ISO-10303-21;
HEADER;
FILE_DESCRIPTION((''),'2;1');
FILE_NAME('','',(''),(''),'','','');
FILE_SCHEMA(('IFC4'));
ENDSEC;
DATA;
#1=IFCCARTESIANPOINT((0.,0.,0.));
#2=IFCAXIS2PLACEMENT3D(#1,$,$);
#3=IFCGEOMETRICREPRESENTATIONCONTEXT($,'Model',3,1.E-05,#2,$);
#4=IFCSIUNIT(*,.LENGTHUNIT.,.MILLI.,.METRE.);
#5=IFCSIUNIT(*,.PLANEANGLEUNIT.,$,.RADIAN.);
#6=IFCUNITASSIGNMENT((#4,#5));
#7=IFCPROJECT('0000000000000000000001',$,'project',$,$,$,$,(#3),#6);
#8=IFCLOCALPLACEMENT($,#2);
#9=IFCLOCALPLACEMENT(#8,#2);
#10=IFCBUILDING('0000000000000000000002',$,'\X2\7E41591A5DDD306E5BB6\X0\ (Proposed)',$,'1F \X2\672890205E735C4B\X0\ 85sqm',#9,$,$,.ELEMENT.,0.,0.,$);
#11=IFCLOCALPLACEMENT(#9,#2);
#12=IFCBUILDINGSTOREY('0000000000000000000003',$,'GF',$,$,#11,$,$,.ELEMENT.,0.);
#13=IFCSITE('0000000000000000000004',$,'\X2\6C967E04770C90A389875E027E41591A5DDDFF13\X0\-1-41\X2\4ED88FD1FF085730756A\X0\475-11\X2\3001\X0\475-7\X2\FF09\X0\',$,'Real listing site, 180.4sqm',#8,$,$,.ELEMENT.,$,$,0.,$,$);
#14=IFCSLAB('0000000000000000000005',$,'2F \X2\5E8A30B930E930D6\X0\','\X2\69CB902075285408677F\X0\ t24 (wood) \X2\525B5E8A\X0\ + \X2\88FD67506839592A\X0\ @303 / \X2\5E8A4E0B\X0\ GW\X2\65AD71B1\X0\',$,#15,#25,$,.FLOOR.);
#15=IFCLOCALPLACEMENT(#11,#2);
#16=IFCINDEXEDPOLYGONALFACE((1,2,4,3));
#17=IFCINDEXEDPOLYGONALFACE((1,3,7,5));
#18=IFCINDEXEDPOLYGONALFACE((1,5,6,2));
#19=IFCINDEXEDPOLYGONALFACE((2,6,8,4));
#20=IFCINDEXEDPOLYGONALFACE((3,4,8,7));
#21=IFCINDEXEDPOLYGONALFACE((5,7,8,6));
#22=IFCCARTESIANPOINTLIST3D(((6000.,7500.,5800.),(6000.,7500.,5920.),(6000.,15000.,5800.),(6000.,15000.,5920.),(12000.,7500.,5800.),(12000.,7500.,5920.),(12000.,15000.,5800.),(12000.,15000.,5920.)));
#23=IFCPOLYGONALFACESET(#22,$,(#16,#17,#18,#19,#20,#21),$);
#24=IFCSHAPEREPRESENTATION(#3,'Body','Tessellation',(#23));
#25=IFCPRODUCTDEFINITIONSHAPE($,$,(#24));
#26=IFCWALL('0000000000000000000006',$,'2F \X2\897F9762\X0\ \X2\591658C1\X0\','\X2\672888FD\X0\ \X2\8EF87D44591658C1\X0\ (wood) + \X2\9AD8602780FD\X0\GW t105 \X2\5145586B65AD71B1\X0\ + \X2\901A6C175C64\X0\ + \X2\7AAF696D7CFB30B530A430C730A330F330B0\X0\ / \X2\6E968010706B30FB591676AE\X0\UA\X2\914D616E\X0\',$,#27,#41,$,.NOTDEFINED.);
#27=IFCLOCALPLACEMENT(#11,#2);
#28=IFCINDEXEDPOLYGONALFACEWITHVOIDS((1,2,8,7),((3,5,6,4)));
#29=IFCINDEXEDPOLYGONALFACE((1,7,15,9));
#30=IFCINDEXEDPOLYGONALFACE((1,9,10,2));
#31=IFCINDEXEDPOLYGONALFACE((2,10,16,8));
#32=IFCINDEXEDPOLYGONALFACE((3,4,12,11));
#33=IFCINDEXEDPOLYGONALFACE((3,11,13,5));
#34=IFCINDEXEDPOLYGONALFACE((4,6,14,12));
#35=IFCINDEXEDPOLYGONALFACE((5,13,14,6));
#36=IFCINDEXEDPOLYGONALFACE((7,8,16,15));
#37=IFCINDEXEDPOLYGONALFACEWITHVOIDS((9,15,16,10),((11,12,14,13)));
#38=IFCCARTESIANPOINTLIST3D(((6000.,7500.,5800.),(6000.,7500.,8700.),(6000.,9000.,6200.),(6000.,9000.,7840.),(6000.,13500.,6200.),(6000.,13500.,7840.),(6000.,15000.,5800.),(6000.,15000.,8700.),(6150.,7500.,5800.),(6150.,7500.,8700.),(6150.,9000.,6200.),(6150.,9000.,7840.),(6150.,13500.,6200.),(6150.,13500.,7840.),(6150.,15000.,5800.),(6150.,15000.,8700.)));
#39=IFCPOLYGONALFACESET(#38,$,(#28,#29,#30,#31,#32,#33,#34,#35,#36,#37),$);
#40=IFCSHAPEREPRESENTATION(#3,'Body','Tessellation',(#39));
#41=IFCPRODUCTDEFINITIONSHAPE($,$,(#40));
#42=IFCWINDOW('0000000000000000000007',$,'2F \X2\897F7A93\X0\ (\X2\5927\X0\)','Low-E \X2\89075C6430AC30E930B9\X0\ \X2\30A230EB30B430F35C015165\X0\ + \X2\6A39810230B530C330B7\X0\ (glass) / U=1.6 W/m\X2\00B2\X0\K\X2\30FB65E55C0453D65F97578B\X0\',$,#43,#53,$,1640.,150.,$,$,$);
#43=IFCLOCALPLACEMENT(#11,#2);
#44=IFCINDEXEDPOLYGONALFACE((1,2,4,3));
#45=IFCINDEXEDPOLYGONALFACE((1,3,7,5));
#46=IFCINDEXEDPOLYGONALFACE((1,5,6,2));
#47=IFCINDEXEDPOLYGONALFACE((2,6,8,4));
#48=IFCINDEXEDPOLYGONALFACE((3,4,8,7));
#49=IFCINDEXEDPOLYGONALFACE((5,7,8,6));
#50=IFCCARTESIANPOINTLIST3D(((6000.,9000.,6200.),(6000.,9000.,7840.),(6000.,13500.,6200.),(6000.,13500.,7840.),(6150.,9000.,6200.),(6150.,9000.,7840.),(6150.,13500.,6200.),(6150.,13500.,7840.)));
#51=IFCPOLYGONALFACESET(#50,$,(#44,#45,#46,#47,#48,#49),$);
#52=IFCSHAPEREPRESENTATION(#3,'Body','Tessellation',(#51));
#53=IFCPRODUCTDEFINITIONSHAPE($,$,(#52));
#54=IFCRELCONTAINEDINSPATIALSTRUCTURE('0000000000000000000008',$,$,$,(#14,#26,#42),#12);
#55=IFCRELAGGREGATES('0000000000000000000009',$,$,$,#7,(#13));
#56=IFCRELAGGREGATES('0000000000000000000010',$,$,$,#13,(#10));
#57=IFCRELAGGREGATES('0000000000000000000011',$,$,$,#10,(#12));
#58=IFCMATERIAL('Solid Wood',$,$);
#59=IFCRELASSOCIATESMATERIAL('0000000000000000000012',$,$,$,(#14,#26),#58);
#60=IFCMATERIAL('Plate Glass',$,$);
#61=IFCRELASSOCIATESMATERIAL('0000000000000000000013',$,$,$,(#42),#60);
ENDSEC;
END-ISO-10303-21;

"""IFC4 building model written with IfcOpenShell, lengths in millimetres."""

from ifc_helpers import new_model, si_unit, frame, frame_2d, origin, place, context, project, spatial, rectangle, extrude, material, element, fill, save


model = new_model("IFC4")

# Units and contexts
model_context = context("Model", 3, precision=1e-05, world=origin())
ifc_project = project(units=[si_unit("LENGTHUNIT", "METRE", prefix="MILLI"), si_unit("PLANEANGLEUNIT", "RADIAN")], contexts=[model_context])

# Site, building, storey
site_placement = place(None, origin())
site = spatial("IfcSite", under=ifc_project, at=site_placement, Name="沖縄県那覇市繁多川３-1-41付近（地番475-11、475-7）", ObjectType="Real listing site, 180.4sqm", CompositionType="ELEMENT", RefElevation=0.0)
building_placement = place(site_placement, origin())
building = spatial("IfcBuilding", under=site, at=building_placement, Name="繁多川の家 (Proposed)", ObjectType="1F 木造平屋 85sqm", CompositionType="ELEMENT", ElevationOfRefHeight=0.0, ElevationOfTerrain=0.0)
storey_placement = place(building_placement, origin())
storey = spatial("IfcBuildingStorey", under=building, at=storey_placement, Name="GF", CompositionType="ELEMENT", Elevation=0.0)

# Slab
ifc_material_1 = material(Name="Solid Wood")
slab_placement = place(storey_placement, frame((3000.0, 3750.0, 2900.0)))
element("IfcSlab", 1, at=slab_placement, inside=storey, material=ifc_material_1, Name="2F 床スラブ", Description="構造用合板 t24 (wood) 剛床 + 製材根太 @303 / 床下 GW断熱", PredefinedType="FLOOR", context=model_context, shape_type="SweptSolid", body=[
    extrude(rectangle(XDim=6000.0, YDim=7500.0, at=frame_2d((3000.0, 3750.0))), frame((3000.0, 3750.0, 2900.0)), (0.0, 0.0, 1.0), 120.0),
])

# Shared definitions
ifc_material_2 = material(Name="Plate Glass")

# Wall, opening, window
wall_1_placement = place(storey_placement, frame((3000.0, 3750.0, 2900.0)))
wall_1 = element("IfcWall", 2, at=wall_1_placement, inside=storey, material=ifc_material_1, Name="2F 西面 外壁", Description="木製 軸組外壁 (wood) + 高性能GW t105 充填断熱 + 通気層 + 窯業系サイディング / 準耐火・外皮UA配慮", PredefinedType="NOTDEFINED", context=model_context, shape_type="SweptSolid", body=[
    extrude(rectangle(XDim=150.0, YDim=7500.0, at=frame_2d((75.0, 3750.0))), frame((3000.0, 3750.0, 2900.0)), (0.0, 0.0, 1.0), 2900.0),
])
opening_1_placement = place(storey_placement, frame((3000.0, 4500.0, 3100.0)))
opening_1 = element("IfcOpeningElement", 3, at=opening_1_placement, cuts=wall_1, PredefinedType="NOTDEFINED", context=model_context, shape_type="SweptSolid", body=[
    extrude(rectangle(XDim=150.0, YDim=4500.0, at=frame_2d((75.0, 2250.0))), frame((3000.0, 4500.0, 3100.0)), (0.0, 0.0, 1.0), 1640.0),
])
window_1_placement = place(storey_placement, frame((3000.0, 4500.0, 3100.0)))
window_1 = element("IfcWindow", 4, at=window_1_placement, inside=storey, material=ifc_material_2, Name="2F 西窓 (大)", Description="Low-E 複層ガラス アルゴン封入 + 樹脂サッシ (glass) / U=1.6 W/m²K・日射取得型", OverallHeight=1640.0, OverallWidth=150.0, context=model_context, shape_type="SweptSolid", body=[
    extrude(rectangle(XDim=150.0, YDim=4500.0, at=frame_2d((75.0, 2250.0))), frame((3000.0, 4500.0, 3100.0)), (0.0, 0.0, 1.0), 1640.0),
])
fill(opening_1, window_1)

save(model, "model.ifc")
